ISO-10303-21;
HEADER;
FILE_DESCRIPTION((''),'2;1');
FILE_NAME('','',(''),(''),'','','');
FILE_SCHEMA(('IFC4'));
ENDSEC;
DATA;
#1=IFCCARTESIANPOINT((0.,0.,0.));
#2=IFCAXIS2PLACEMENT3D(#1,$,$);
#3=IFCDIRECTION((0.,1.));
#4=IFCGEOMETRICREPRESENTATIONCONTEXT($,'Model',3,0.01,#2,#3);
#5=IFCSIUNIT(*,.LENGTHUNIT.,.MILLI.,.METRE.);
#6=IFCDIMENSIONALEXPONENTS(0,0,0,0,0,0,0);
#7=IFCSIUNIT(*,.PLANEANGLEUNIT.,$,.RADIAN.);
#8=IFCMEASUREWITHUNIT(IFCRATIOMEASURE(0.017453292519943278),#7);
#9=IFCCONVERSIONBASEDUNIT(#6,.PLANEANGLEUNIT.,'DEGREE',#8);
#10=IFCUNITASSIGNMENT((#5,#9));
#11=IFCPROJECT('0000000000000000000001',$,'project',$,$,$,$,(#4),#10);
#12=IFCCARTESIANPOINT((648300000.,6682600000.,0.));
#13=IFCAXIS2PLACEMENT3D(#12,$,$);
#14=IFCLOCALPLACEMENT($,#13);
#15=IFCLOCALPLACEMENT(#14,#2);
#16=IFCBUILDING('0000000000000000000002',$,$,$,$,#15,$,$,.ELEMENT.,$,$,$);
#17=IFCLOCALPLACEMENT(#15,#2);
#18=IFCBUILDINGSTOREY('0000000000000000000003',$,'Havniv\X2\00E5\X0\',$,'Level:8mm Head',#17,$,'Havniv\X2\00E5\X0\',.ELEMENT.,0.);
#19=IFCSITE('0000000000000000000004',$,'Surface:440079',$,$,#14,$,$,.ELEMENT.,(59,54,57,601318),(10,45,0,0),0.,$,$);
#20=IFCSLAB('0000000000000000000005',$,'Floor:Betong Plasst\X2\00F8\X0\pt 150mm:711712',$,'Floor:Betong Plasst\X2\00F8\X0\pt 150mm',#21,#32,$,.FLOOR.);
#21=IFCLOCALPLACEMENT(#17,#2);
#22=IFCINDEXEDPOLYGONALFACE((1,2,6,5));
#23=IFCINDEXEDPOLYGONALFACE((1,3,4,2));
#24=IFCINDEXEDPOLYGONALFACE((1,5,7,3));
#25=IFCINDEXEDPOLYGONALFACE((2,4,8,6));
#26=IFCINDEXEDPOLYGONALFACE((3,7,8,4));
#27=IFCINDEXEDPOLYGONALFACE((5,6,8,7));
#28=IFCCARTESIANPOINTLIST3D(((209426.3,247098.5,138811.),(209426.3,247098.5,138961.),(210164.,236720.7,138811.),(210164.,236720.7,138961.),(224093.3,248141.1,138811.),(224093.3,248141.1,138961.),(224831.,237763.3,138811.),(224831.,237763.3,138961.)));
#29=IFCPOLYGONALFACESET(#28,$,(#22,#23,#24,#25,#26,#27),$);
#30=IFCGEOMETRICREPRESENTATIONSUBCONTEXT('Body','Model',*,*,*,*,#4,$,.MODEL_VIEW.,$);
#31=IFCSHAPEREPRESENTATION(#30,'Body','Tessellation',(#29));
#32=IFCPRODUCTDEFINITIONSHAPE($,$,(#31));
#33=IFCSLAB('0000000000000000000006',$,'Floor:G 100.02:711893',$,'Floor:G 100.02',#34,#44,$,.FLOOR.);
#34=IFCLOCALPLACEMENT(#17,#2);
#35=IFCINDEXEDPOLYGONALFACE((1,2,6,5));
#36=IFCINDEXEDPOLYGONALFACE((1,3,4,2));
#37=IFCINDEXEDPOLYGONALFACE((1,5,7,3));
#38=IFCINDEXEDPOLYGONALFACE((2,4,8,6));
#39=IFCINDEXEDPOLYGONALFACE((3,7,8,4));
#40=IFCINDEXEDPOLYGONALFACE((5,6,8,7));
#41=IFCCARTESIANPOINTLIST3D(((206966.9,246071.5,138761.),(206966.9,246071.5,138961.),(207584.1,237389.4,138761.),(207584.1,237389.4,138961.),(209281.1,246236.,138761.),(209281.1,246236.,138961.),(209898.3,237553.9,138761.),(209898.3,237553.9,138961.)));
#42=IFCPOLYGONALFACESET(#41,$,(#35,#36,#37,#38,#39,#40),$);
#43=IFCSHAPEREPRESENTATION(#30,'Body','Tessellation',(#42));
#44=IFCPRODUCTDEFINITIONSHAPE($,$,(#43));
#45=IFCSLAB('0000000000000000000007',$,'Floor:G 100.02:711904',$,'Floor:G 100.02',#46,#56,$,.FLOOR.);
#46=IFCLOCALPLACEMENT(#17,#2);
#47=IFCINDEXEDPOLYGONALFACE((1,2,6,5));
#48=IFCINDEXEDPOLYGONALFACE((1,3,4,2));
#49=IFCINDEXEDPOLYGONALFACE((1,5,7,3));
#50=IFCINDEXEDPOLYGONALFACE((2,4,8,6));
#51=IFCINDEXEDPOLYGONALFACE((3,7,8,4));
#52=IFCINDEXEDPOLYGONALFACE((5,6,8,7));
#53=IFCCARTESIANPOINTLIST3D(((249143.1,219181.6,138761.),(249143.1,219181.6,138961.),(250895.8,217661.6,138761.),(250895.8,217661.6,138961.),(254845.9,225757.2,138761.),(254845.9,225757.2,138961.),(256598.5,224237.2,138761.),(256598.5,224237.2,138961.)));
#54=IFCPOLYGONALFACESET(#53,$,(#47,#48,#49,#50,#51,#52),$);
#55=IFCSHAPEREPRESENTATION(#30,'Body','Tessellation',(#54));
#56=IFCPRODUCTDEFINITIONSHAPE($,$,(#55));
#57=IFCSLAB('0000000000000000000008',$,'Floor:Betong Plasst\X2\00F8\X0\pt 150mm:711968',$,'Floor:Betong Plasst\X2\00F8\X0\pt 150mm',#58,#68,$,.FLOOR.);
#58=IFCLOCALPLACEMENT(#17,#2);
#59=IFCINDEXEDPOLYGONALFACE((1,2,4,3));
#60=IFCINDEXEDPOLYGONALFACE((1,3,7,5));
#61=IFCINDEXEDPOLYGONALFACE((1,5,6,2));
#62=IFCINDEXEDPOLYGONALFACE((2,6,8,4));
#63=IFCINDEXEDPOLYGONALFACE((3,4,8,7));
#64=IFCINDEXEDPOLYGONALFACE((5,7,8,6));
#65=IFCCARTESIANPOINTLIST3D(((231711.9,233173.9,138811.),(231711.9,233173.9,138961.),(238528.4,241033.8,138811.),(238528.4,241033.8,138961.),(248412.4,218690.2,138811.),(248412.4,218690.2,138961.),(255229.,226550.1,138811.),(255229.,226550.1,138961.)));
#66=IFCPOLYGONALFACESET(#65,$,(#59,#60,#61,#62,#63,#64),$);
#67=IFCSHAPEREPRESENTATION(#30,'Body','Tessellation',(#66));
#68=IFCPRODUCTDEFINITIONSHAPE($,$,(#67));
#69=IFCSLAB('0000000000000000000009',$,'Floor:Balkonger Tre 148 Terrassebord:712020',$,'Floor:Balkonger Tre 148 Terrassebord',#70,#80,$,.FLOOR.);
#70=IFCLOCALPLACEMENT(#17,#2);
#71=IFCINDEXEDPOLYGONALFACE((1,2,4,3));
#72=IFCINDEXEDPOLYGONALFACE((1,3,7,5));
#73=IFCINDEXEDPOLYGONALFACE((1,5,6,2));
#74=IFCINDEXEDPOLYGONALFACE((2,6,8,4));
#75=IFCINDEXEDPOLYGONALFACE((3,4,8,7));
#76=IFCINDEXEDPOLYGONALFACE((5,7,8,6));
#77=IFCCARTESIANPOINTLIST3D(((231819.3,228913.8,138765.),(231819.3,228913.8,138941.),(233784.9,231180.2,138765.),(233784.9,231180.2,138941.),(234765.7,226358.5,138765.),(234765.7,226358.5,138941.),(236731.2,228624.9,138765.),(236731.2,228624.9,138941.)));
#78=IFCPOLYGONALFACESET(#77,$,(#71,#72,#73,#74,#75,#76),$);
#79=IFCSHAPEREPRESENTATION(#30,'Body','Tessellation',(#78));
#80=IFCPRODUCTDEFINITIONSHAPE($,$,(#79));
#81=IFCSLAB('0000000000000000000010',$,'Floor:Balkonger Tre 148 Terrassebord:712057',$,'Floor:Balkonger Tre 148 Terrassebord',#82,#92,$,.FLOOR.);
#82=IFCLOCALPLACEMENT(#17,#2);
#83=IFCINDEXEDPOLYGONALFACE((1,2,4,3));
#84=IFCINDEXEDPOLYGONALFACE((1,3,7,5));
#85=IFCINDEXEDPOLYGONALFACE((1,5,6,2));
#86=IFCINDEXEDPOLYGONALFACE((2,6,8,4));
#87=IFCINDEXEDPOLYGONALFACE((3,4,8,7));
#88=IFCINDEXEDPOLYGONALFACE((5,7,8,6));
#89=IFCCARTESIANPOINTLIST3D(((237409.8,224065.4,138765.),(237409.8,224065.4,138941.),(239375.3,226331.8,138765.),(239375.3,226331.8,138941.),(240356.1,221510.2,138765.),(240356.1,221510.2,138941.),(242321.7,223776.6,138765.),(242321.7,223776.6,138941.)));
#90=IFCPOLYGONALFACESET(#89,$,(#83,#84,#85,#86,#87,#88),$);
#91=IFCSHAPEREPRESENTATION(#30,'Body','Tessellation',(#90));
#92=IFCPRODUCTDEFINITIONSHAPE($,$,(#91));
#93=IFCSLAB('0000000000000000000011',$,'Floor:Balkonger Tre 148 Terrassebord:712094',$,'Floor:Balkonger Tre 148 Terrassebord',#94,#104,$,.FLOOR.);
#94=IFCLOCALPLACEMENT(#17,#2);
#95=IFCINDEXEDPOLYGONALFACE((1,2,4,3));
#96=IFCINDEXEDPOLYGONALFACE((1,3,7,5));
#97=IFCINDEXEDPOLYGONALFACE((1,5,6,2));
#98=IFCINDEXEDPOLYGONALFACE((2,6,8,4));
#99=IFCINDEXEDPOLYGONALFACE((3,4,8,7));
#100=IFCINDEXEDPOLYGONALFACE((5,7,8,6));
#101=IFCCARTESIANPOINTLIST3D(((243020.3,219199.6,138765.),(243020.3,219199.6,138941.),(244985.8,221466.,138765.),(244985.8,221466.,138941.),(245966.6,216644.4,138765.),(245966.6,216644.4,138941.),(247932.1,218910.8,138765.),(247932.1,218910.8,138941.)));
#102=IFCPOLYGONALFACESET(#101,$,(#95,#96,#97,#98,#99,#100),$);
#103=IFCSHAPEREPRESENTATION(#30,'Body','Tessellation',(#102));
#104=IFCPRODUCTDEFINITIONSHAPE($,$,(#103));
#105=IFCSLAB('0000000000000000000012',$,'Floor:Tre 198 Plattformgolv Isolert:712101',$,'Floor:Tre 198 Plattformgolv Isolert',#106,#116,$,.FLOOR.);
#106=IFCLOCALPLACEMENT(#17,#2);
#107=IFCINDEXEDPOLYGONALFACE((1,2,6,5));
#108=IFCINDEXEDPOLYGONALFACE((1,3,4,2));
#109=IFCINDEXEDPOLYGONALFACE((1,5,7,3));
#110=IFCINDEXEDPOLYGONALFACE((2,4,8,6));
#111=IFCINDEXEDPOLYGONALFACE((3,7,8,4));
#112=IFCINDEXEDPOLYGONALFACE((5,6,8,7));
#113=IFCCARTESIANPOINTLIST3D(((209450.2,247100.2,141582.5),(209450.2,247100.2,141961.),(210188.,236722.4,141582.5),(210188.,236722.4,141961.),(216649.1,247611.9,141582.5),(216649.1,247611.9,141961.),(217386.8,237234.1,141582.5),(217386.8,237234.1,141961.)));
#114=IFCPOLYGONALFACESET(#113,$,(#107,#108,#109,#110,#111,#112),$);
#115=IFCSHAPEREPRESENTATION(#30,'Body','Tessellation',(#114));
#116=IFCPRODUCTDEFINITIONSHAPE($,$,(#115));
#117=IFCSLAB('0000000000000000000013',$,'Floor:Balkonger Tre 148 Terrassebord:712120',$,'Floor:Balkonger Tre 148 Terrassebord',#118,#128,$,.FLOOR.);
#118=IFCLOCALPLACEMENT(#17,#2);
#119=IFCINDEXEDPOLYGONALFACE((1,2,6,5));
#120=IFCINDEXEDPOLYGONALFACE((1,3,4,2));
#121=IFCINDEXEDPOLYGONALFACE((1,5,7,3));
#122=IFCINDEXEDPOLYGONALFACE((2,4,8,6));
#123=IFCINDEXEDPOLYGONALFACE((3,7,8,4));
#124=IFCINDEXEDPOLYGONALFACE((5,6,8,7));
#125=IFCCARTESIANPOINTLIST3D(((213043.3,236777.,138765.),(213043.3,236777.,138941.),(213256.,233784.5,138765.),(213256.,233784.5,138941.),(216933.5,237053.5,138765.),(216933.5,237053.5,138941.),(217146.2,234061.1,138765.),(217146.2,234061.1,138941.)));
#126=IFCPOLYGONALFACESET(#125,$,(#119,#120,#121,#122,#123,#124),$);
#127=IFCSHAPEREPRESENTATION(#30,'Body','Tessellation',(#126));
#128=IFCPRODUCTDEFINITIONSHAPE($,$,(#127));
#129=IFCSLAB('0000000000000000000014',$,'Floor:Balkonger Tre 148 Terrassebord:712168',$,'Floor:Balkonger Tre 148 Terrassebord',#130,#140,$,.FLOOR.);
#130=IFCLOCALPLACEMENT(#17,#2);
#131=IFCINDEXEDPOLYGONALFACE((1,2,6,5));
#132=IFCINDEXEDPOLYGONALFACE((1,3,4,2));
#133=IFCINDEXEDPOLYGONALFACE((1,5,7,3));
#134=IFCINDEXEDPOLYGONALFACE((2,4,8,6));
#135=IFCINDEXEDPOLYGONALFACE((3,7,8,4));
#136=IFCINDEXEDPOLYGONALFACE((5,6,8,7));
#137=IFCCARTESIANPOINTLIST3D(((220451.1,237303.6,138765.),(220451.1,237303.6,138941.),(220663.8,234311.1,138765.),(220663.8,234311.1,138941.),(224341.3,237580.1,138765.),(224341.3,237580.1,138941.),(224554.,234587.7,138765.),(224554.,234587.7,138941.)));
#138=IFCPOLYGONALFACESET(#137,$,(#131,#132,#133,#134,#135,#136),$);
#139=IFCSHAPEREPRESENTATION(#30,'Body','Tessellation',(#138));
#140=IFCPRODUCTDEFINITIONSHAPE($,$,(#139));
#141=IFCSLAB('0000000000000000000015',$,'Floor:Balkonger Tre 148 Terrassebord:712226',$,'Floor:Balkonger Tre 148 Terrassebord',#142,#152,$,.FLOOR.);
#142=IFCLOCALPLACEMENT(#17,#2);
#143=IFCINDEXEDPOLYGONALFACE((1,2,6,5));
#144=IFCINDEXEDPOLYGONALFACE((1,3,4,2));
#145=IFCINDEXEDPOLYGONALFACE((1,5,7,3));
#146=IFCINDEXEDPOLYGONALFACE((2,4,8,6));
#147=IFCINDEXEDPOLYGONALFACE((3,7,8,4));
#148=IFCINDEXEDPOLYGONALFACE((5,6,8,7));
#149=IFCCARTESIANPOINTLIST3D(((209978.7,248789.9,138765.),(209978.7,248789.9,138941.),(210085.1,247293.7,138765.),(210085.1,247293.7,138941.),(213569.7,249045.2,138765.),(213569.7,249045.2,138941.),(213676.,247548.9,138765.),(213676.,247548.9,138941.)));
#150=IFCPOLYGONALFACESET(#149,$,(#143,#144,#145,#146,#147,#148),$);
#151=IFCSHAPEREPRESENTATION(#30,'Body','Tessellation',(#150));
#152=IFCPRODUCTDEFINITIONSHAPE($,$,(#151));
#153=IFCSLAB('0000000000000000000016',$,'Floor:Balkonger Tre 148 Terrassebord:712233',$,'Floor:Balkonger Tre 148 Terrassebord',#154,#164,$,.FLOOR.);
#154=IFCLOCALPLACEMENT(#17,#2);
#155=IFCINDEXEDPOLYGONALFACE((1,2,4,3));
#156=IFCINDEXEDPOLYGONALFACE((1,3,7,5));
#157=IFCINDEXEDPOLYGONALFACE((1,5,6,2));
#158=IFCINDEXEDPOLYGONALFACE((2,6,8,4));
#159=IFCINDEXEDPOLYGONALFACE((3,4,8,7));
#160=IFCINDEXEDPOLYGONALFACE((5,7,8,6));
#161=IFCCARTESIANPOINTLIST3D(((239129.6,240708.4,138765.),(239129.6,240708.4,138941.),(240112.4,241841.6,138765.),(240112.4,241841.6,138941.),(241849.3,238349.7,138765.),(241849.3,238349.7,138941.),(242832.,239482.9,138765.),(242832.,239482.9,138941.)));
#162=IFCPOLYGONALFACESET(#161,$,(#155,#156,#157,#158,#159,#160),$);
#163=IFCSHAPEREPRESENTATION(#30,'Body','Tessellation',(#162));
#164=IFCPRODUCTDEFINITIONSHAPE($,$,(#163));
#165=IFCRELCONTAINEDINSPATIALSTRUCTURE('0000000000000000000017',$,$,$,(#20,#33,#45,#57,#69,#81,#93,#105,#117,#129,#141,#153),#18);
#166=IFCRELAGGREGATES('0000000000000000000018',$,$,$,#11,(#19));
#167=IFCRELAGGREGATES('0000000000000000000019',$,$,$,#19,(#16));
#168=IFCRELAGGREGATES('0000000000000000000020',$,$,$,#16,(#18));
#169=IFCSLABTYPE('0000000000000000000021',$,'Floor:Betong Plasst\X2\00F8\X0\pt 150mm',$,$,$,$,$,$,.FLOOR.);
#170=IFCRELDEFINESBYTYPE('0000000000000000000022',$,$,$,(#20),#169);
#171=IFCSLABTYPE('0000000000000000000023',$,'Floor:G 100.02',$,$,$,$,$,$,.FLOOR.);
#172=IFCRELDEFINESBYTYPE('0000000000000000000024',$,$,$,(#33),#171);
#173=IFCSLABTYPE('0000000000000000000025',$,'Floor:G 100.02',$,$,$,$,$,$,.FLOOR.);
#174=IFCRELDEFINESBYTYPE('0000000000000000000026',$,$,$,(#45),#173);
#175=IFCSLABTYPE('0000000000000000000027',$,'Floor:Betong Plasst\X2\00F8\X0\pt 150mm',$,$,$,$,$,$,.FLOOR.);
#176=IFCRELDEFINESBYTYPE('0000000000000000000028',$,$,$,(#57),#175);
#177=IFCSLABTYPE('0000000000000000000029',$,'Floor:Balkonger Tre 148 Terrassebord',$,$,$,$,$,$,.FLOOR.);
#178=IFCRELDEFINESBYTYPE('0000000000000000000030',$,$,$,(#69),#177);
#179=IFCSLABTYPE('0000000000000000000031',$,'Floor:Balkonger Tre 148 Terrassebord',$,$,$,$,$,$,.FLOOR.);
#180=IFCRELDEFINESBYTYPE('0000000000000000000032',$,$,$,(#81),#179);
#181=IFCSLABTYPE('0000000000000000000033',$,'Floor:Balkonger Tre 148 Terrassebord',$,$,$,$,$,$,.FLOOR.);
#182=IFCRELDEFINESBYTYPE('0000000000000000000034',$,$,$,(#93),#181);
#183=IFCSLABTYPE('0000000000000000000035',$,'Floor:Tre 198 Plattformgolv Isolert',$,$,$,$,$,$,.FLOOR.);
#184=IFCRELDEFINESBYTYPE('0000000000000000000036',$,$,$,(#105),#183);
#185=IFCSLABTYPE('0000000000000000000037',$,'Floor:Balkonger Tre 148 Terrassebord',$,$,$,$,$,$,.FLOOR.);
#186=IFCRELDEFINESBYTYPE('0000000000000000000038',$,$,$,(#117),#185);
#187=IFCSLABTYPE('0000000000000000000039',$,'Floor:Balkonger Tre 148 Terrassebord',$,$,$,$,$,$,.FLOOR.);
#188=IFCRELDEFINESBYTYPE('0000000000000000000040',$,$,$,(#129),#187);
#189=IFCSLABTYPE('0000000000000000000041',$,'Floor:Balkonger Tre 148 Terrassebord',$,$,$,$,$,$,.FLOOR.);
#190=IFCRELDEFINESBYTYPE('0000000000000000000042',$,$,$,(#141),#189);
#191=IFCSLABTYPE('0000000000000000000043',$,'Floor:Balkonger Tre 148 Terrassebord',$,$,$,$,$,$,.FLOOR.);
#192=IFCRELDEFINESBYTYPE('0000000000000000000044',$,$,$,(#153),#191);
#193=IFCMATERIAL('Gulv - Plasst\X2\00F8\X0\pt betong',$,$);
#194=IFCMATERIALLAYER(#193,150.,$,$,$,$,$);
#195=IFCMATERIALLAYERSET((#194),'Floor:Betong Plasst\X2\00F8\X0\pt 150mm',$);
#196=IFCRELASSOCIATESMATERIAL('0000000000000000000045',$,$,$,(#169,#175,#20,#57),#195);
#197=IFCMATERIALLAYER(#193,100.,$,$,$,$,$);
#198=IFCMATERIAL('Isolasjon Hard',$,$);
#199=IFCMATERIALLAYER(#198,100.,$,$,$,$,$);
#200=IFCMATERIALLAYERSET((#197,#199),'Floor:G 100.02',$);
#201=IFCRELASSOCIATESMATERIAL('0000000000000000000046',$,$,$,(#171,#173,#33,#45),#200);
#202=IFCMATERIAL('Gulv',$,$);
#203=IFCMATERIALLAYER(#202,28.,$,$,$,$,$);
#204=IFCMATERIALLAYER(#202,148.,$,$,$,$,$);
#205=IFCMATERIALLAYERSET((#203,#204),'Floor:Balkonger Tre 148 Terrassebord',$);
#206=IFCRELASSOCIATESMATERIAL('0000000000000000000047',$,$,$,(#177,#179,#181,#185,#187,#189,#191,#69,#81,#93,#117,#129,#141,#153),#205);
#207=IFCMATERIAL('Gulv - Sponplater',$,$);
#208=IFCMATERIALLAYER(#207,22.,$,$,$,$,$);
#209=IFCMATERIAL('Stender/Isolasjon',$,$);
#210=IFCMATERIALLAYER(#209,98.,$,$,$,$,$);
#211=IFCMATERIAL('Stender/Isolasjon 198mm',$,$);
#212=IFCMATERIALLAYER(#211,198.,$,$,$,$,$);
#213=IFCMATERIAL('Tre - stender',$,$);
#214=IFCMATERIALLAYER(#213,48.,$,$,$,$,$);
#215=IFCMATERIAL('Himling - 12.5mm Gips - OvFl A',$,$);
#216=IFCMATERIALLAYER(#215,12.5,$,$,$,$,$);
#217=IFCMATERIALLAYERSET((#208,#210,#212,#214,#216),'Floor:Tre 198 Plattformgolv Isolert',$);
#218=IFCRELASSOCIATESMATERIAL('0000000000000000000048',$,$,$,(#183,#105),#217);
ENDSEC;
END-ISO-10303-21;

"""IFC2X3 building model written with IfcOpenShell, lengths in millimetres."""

from ifc_helpers import new_model, entity, si_unit, converted_unit, direction, frame, frame_2d, origin, origin_2d_with_axis, place, context, subcontext, project, spatial, rectangle, extrude, material, layer, layer_set, layer_usage, type_object, element, save


model = new_model("IFC2X3")

# Units and contexts
model_context = context("Model", 3, precision=0.01, world=origin(), true_north=direction((0.0, 1.0)))
body_context = subcontext(model_context, "Body", "Model", "MODEL_VIEW")
ifc_project = project(units=[si_unit("LENGTHUNIT", "METRE", prefix="MILLI"), converted_unit("PLANEANGLEUNIT", "DEGREE", entity("IfcRatioMeasure", 0.017453292519943278), si_unit("PLANEANGLEUNIT", "RADIAN"), dimensions=[0, 0, 0, 0, 0, 0, 0])], contexts=[model_context])

# Site, building, storey
site_placement = place(None, frame((648300000.0, 6682600000.0, 0.0)))
site = spatial("IfcSite", under=ifc_project, at=site_placement, Name="Surface:440079", CompositionType="ELEMENT", RefLatitude=(59, 54, 57, 601318), RefLongitude=(10, 45, 0, 0), RefElevation=0.0)
building_placement = place(site_placement, origin())
building = spatial("IfcBuilding", under=site, at=building_placement, CompositionType="ELEMENT")
storey_placement = place(building_placement, origin())
storey = spatial("IfcBuildingStorey", under=building, at=storey_placement, Name="Havnivå", ObjectType="Level:8mm Head", LongName="Havnivå", CompositionType="ELEMENT", Elevation=0.0)

# Slabs
ifc_material_1 = material(Name="Gulv - Plasstøpt betong")
ifc_layer_1 = layer(ifc_material_1, 150.0)
ifc_layer_set_1 = layer_set([ifc_layer_1], Name="Floor:Betong Plasstøpt 150mm")
ifc_layer_usage_1 = layer_usage(ifc_layer_set_1, "AXIS3", "POSITIVE", 0.0)
slab_type_1 = type_object("IfcSlabType", Name="Floor:Betong Plasstøpt 150mm", PredefinedType="FLOOR", material=ifc_layer_set_1)
slab_1_placement = place(storey_placement, origin())
element("IfcSlab", 1, at=slab_1_placement, inside=storey, type_object=slab_type_1, material=ifc_layer_usage_1, Name="Floor:Betong Plasstøpt 150mm:711712", ObjectType="Floor:Betong Plasstøpt 150mm", PredefinedType="FLOOR", context=body_context, shape_type="SweptSolid", body=[
    extrude(rectangle(XDim=10404.0, YDim=14704.0, at=frame_2d((0.0, 0.0), x_axis=(1.0, 0.0))), frame((217128.6, 242430.9, 138961.0), z_axis=(0.0, 0.0, -1.0), x_axis=(0.070908, -0.997483, 0.0)), (0.0, 0.0, 1.0), 150.0),
])
ifc_material_2 = material(Name="Gulv")
ifc_layer_2 = layer(ifc_material_2, 28.0)
ifc_layer_3 = layer(ifc_material_2, 148.0)
ifc_layer_set_2 = layer_set([ifc_layer_2, ifc_layer_3], Name="Floor:Balkonger Tre 148 Terrassebord")
ifc_layer_4 = layer(ifc_material_1, 100.0)
ifc_material_3 = material(Name="Isolasjon Hard")
ifc_layer_5 = layer(ifc_material_3, 100.0)
ifc_layer_set_3 = layer_set([ifc_layer_4, ifc_layer_5], Name="Floor:G 100.02")
ifc_layer_usage_2 = layer_usage(ifc_layer_set_3, "AXIS3", "POSITIVE", 0.0)
slab_type_2 = type_object("IfcSlabType", Name="Floor:G 100.02", PredefinedType="FLOOR", material=ifc_layer_set_3)
slab_2_placement = place(storey_placement, origin())
element("IfcSlab", 2, at=slab_2_placement, inside=storey, type_object=slab_type_2, material=ifc_layer_usage_2, Name="Floor:G 100.02:711893", ObjectType="Floor:G 100.02", PredefinedType="FLOOR", context=body_context, shape_type="SweptSolid", body=[
    extrude(rectangle(XDim=2320.0, YDim=8704.0, at=origin_2d_with_axis()), frame((208432.6, 241812.7, 138961.0), z_axis=(0.0, 0.0, -1.0), x_axis=(0.997483, 0.070908, 0.0)), (0.0, 0.0, 1.0), 200.0),
])
ifc_layer_usage_3 = layer_usage(ifc_layer_set_3, "AXIS3", "POSITIVE", 0.0)
slab_type_3 = type_object("IfcSlabType", Name="Floor:G 100.02", PredefinedType="FLOOR", material=ifc_layer_set_3)
slab_3_placement = place(storey_placement, origin())
element("IfcSlab", 3, at=slab_3_placement, inside=storey, type_object=slab_type_3, material=ifc_layer_usage_3, Name="Floor:G 100.02:711904", ObjectType="Floor:G 100.02", PredefinedType="FLOOR", context=body_context, shape_type="SweptSolid", body=[
    extrude(rectangle(XDim=8704.0, YDim=2320.0, at=frame_2d((0.0, 0.0), x_axis=(1.0, 0.0))), frame((252870.8, 221709.4, 138961.0), z_axis=(0.0, 0.0, -1.0), x_axis=(-0.655187, -0.755467, 0.0)), (0.0, 0.0, 1.0), 200.0),
])
ifc_layer_usage_4 = layer_usage(ifc_layer_set_1, "AXIS3", "POSITIVE", 0.0)
slab_type_4 = type_object("IfcSlabType", Name="Floor:Betong Plasstøpt 150mm", PredefinedType="FLOOR", material=ifc_layer_set_1)
slab_4_placement = place(storey_placement, origin())
element("IfcSlab", 4, at=slab_4_placement, inside=storey, type_object=slab_type_4, material=ifc_layer_usage_4, Name="Floor:Betong Plasstøpt 150mm:711968", ObjectType="Floor:Betong Plasstøpt 150mm", PredefinedType="FLOOR", context=body_context, shape_type="SweptSolid", body=[
    extrude(rectangle(XDim=22106.3, YDim=10404.0, at=origin_2d_with_axis()), frame((243470.4, 229862.0, 138961.0), z_axis=(0.0, 0.0, -1.0), x_axis=(0.755467, -0.655187, 0.0)), (0.0, 0.0, 1.0), 150.0),
])
ifc_layer_usage_5 = layer_usage(ifc_layer_set_2, "AXIS3", "POSITIVE", 0.0)
slab_type_5 = type_object("IfcSlabType", Name="Floor:Balkonger Tre 148 Terrassebord", PredefinedType="FLOOR", material=ifc_layer_set_2)
slab_5_placement = place(storey_placement, origin())
element("IfcSlab", 5, at=slab_5_placement, inside=storey, type_object=slab_type_5, material=ifc_layer_usage_5, Name="Floor:Balkonger Tre 148 Terrassebord:712020", ObjectType="Floor:Balkonger Tre 148 Terrassebord", PredefinedType="FLOOR", context=body_context, shape_type="SweptSolid", body=[
    extrude(rectangle(XDim=3000.0, YDim=3900.0, at=frame_2d((0.0, 0.0), x_axis=(1.0, 0.0))), frame((234275.3, 228769.4, 138941.0), z_axis=(0.0, 0.0, -1.0), x_axis=(-0.655187, -0.755467, 0.0)), (0.0, 0.0, 1.0), 176.0),
])
ifc_layer_usage_6 = layer_usage(ifc_layer_set_2, "AXIS3", "POSITIVE", 0.0)
slab_type_6 = type_object("IfcSlabType", Name="Floor:Balkonger Tre 148 Terrassebord", PredefinedType="FLOOR", material=ifc_layer_set_2)
slab_6_placement = place(storey_placement, origin())
element("IfcSlab", 6, at=slab_6_placement, inside=storey, type_object=slab_type_6, material=ifc_layer_usage_6, Name="Floor:Balkonger Tre 148 Terrassebord:712057", ObjectType="Floor:Balkonger Tre 148 Terrassebord", PredefinedType="FLOOR", context=body_context, shape_type="SweptSolid", body=[
    extrude(rectangle(XDim=3000.0, YDim=3900.0, at=frame_2d((0.0, 0.0), x_axis=(1.0, 0.0))), frame((239865.7, 223921.0, 138941.0), z_axis=(0.0, 0.0, -1.0), x_axis=(-0.655187, -0.755467, 0.0)), (0.0, 0.0, 1.0), 176.0),
])
ifc_layer_usage_7 = layer_usage(ifc_layer_set_2, "AXIS3", "POSITIVE", 0.0)
slab_type_7 = type_object("IfcSlabType", Name="Floor:Balkonger Tre 148 Terrassebord", PredefinedType="FLOOR", material=ifc_layer_set_2)
slab_7_placement = place(storey_placement, origin())
element("IfcSlab", 7, at=slab_7_placement, inside=storey, type_object=slab_type_7, material=ifc_layer_usage_7, Name="Floor:Balkonger Tre 148 Terrassebord:712094", ObjectType="Floor:Balkonger Tre 148 Terrassebord", PredefinedType="FLOOR", context=body_context, shape_type="SweptSolid", body=[
    extrude(rectangle(XDim=3000.0, YDim=3900.0, at=frame_2d((0.0, 0.0), x_axis=(1.0, 0.0))), frame((245476.2, 219055.2, 138941.0), z_axis=(0.0, 0.0, -1.0), x_axis=(-0.655187, -0.755467, 0.0)), (0.0, 0.0, 1.0), 176.0),
])
ifc_material_4 = material(Name="Gulv - Sponplater")
ifc_layer_6 = layer(ifc_material_4, 22.0)
ifc_material_5 = material(Name="Stender/Isolasjon")
ifc_layer_7 = layer(ifc_material_5, 98.0)
ifc_material_6 = material(Name="Stender/Isolasjon 198mm")
ifc_layer_8 = layer(ifc_material_6, 198.0)
ifc_material_7 = material(Name="Tre - stender")
ifc_layer_9 = layer(ifc_material_7, 48.0)
ifc_material_8 = material(Name="Himling - 12.5mm Gips - OvFl A")
ifc_layer_10 = layer(ifc_material_8, 12.5)
ifc_layer_set_4 = layer_set([ifc_layer_6, ifc_layer_7, ifc_layer_8, ifc_layer_9, ifc_layer_10], Name="Floor:Tre 198 Plattformgolv Isolert")
ifc_layer_usage_8 = layer_usage(ifc_layer_set_4, "AXIS3", "POSITIVE", 0.0)
slab_type_8 = type_object("IfcSlabType", Name="Floor:Tre 198 Plattformgolv Isolert", PredefinedType="FLOOR", material=ifc_layer_set_4)
slab_8_placement = place(storey_placement, origin())
element("IfcSlab", 8, at=slab_8_placement, inside=storey, type_object=slab_type_8, material=ifc_layer_usage_8, Name="Floor:Tre 198 Plattformgolv Isolert:712101", ObjectType="Floor:Tre 198 Plattformgolv Isolert", PredefinedType="FLOOR", context=body_context, shape_type="SweptSolid", body=[
    extrude(rectangle(XDim=10404.0, YDim=7217.0, at=origin_2d_with_axis()), frame((213418.5, 242167.1, 141961.0), z_axis=(0.0, 0.0, -1.0), x_axis=(0.070908, -0.997483, 0.0)), (0.0, 0.0, 1.0), 378.5),
])
ifc_layer_usage_9 = layer_usage(ifc_layer_set_2, "AXIS3", "POSITIVE", 0.0)
slab_type_9 = type_object("IfcSlabType", Name="Floor:Balkonger Tre 148 Terrassebord", PredefinedType="FLOOR", material=ifc_layer_set_2)
slab_9_placement = place(storey_placement, origin())
element("IfcSlab", 9, at=slab_9_placement, inside=storey, type_object=slab_type_9, material=ifc_layer_usage_9, Name="Floor:Balkonger Tre 148 Terrassebord:712120", ObjectType="Floor:Balkonger Tre 148 Terrassebord", PredefinedType="FLOOR", context=body_context, shape_type="SweptSolid", body=[
    extrude(rectangle(XDim=3000.0, YDim=3900.0, at=frame_2d((0.0, 0.0), x_axis=(1.0, 0.0))), frame((215094.7, 235419.0, 138941.0), z_axis=(0.0, 0.0, -1.0), x_axis=(0.070908, -0.997483, 0.0)), (0.0, 0.0, 1.0), 176.0),
])
ifc_layer_usage_10 = layer_usage(ifc_layer_set_2, "AXIS3", "POSITIVE", 0.0)
slab_type_10 = type_object("IfcSlabType", Name="Floor:Balkonger Tre 148 Terrassebord", PredefinedType="FLOOR", material=ifc_layer_set_2)
slab_10_placement = place(storey_placement, origin())
element("IfcSlab", 10, at=slab_10_placement, inside=storey, type_object=slab_type_10, material=ifc_layer_usage_10, Name="Floor:Balkonger Tre 148 Terrassebord:712168", ObjectType="Floor:Balkonger Tre 148 Terrassebord", PredefinedType="FLOOR", context=body_context, shape_type="SweptSolid", body=[
    extrude(rectangle(XDim=3000.0, YDim=3900.0, at=frame_2d((0.0, 0.0), x_axis=(1.0, 0.0))), frame((222502.5, 235945.6, 138941.0), z_axis=(0.0, 0.0, -1.0), x_axis=(0.070908, -0.997483, 0.0)), (0.0, 0.0, 1.0), 176.0),
])
ifc_layer_usage_11 = layer_usage(ifc_layer_set_2, "AXIS3", "POSITIVE", 0.0)
slab_type_11 = type_object("IfcSlabType", Name="Floor:Balkonger Tre 148 Terrassebord", PredefinedType="FLOOR", material=ifc_layer_set_2)
slab_11_placement = place(storey_placement, origin())
element("IfcSlab", 11, at=slab_11_placement, inside=storey, type_object=slab_type_11, material=ifc_layer_usage_11, Name="Floor:Balkonger Tre 148 Terrassebord:712226", ObjectType="Floor:Balkonger Tre 148 Terrassebord", PredefinedType="FLOOR", context=body_context, shape_type="SweptSolid", body=[
    extrude(rectangle(XDim=1500.0, YDim=3600.0, at=frame_2d((0.0, 0.0), x_axis=(1.0, 0.0))), frame((211827.4, 248169.4, 138941.0), z_axis=(0.0, 0.0, -1.0), x_axis=(0.070908, -0.997483, 0.0)), (0.0, 0.0, 1.0), 176.0),
])
ifc_layer_usage_12 = layer_usage(ifc_layer_set_2, "AXIS3", "POSITIVE", 0.0)
slab_type_12 = type_object("IfcSlabType", Name="Floor:Balkonger Tre 148 Terrassebord", PredefinedType="FLOOR", material=ifc_layer_set_2)
slab_12_placement = place(storey_placement, origin())
element("IfcSlab", 12, at=slab_12_placement, inside=storey, type_object=slab_type_12, material=ifc_layer_usage_12, Name="Floor:Balkonger Tre 148 Terrassebord:712233", ObjectType="Floor:Balkonger Tre 148 Terrassebord", PredefinedType="FLOOR", context=body_context, shape_type="SweptSolid", body=[
    extrude(rectangle(XDim=1500.0, YDim=3600.0, at=frame_2d((0.0, 0.0), x_axis=(1.0, 0.0))), frame((240980.8, 240095.6, 138941.0), z_axis=(0.0, 0.0, -1.0), x_axis=(-0.655187, -0.755467, 0.0)), (0.0, 0.0, 1.0), 176.0),
])

save(model, "model.ifc")
